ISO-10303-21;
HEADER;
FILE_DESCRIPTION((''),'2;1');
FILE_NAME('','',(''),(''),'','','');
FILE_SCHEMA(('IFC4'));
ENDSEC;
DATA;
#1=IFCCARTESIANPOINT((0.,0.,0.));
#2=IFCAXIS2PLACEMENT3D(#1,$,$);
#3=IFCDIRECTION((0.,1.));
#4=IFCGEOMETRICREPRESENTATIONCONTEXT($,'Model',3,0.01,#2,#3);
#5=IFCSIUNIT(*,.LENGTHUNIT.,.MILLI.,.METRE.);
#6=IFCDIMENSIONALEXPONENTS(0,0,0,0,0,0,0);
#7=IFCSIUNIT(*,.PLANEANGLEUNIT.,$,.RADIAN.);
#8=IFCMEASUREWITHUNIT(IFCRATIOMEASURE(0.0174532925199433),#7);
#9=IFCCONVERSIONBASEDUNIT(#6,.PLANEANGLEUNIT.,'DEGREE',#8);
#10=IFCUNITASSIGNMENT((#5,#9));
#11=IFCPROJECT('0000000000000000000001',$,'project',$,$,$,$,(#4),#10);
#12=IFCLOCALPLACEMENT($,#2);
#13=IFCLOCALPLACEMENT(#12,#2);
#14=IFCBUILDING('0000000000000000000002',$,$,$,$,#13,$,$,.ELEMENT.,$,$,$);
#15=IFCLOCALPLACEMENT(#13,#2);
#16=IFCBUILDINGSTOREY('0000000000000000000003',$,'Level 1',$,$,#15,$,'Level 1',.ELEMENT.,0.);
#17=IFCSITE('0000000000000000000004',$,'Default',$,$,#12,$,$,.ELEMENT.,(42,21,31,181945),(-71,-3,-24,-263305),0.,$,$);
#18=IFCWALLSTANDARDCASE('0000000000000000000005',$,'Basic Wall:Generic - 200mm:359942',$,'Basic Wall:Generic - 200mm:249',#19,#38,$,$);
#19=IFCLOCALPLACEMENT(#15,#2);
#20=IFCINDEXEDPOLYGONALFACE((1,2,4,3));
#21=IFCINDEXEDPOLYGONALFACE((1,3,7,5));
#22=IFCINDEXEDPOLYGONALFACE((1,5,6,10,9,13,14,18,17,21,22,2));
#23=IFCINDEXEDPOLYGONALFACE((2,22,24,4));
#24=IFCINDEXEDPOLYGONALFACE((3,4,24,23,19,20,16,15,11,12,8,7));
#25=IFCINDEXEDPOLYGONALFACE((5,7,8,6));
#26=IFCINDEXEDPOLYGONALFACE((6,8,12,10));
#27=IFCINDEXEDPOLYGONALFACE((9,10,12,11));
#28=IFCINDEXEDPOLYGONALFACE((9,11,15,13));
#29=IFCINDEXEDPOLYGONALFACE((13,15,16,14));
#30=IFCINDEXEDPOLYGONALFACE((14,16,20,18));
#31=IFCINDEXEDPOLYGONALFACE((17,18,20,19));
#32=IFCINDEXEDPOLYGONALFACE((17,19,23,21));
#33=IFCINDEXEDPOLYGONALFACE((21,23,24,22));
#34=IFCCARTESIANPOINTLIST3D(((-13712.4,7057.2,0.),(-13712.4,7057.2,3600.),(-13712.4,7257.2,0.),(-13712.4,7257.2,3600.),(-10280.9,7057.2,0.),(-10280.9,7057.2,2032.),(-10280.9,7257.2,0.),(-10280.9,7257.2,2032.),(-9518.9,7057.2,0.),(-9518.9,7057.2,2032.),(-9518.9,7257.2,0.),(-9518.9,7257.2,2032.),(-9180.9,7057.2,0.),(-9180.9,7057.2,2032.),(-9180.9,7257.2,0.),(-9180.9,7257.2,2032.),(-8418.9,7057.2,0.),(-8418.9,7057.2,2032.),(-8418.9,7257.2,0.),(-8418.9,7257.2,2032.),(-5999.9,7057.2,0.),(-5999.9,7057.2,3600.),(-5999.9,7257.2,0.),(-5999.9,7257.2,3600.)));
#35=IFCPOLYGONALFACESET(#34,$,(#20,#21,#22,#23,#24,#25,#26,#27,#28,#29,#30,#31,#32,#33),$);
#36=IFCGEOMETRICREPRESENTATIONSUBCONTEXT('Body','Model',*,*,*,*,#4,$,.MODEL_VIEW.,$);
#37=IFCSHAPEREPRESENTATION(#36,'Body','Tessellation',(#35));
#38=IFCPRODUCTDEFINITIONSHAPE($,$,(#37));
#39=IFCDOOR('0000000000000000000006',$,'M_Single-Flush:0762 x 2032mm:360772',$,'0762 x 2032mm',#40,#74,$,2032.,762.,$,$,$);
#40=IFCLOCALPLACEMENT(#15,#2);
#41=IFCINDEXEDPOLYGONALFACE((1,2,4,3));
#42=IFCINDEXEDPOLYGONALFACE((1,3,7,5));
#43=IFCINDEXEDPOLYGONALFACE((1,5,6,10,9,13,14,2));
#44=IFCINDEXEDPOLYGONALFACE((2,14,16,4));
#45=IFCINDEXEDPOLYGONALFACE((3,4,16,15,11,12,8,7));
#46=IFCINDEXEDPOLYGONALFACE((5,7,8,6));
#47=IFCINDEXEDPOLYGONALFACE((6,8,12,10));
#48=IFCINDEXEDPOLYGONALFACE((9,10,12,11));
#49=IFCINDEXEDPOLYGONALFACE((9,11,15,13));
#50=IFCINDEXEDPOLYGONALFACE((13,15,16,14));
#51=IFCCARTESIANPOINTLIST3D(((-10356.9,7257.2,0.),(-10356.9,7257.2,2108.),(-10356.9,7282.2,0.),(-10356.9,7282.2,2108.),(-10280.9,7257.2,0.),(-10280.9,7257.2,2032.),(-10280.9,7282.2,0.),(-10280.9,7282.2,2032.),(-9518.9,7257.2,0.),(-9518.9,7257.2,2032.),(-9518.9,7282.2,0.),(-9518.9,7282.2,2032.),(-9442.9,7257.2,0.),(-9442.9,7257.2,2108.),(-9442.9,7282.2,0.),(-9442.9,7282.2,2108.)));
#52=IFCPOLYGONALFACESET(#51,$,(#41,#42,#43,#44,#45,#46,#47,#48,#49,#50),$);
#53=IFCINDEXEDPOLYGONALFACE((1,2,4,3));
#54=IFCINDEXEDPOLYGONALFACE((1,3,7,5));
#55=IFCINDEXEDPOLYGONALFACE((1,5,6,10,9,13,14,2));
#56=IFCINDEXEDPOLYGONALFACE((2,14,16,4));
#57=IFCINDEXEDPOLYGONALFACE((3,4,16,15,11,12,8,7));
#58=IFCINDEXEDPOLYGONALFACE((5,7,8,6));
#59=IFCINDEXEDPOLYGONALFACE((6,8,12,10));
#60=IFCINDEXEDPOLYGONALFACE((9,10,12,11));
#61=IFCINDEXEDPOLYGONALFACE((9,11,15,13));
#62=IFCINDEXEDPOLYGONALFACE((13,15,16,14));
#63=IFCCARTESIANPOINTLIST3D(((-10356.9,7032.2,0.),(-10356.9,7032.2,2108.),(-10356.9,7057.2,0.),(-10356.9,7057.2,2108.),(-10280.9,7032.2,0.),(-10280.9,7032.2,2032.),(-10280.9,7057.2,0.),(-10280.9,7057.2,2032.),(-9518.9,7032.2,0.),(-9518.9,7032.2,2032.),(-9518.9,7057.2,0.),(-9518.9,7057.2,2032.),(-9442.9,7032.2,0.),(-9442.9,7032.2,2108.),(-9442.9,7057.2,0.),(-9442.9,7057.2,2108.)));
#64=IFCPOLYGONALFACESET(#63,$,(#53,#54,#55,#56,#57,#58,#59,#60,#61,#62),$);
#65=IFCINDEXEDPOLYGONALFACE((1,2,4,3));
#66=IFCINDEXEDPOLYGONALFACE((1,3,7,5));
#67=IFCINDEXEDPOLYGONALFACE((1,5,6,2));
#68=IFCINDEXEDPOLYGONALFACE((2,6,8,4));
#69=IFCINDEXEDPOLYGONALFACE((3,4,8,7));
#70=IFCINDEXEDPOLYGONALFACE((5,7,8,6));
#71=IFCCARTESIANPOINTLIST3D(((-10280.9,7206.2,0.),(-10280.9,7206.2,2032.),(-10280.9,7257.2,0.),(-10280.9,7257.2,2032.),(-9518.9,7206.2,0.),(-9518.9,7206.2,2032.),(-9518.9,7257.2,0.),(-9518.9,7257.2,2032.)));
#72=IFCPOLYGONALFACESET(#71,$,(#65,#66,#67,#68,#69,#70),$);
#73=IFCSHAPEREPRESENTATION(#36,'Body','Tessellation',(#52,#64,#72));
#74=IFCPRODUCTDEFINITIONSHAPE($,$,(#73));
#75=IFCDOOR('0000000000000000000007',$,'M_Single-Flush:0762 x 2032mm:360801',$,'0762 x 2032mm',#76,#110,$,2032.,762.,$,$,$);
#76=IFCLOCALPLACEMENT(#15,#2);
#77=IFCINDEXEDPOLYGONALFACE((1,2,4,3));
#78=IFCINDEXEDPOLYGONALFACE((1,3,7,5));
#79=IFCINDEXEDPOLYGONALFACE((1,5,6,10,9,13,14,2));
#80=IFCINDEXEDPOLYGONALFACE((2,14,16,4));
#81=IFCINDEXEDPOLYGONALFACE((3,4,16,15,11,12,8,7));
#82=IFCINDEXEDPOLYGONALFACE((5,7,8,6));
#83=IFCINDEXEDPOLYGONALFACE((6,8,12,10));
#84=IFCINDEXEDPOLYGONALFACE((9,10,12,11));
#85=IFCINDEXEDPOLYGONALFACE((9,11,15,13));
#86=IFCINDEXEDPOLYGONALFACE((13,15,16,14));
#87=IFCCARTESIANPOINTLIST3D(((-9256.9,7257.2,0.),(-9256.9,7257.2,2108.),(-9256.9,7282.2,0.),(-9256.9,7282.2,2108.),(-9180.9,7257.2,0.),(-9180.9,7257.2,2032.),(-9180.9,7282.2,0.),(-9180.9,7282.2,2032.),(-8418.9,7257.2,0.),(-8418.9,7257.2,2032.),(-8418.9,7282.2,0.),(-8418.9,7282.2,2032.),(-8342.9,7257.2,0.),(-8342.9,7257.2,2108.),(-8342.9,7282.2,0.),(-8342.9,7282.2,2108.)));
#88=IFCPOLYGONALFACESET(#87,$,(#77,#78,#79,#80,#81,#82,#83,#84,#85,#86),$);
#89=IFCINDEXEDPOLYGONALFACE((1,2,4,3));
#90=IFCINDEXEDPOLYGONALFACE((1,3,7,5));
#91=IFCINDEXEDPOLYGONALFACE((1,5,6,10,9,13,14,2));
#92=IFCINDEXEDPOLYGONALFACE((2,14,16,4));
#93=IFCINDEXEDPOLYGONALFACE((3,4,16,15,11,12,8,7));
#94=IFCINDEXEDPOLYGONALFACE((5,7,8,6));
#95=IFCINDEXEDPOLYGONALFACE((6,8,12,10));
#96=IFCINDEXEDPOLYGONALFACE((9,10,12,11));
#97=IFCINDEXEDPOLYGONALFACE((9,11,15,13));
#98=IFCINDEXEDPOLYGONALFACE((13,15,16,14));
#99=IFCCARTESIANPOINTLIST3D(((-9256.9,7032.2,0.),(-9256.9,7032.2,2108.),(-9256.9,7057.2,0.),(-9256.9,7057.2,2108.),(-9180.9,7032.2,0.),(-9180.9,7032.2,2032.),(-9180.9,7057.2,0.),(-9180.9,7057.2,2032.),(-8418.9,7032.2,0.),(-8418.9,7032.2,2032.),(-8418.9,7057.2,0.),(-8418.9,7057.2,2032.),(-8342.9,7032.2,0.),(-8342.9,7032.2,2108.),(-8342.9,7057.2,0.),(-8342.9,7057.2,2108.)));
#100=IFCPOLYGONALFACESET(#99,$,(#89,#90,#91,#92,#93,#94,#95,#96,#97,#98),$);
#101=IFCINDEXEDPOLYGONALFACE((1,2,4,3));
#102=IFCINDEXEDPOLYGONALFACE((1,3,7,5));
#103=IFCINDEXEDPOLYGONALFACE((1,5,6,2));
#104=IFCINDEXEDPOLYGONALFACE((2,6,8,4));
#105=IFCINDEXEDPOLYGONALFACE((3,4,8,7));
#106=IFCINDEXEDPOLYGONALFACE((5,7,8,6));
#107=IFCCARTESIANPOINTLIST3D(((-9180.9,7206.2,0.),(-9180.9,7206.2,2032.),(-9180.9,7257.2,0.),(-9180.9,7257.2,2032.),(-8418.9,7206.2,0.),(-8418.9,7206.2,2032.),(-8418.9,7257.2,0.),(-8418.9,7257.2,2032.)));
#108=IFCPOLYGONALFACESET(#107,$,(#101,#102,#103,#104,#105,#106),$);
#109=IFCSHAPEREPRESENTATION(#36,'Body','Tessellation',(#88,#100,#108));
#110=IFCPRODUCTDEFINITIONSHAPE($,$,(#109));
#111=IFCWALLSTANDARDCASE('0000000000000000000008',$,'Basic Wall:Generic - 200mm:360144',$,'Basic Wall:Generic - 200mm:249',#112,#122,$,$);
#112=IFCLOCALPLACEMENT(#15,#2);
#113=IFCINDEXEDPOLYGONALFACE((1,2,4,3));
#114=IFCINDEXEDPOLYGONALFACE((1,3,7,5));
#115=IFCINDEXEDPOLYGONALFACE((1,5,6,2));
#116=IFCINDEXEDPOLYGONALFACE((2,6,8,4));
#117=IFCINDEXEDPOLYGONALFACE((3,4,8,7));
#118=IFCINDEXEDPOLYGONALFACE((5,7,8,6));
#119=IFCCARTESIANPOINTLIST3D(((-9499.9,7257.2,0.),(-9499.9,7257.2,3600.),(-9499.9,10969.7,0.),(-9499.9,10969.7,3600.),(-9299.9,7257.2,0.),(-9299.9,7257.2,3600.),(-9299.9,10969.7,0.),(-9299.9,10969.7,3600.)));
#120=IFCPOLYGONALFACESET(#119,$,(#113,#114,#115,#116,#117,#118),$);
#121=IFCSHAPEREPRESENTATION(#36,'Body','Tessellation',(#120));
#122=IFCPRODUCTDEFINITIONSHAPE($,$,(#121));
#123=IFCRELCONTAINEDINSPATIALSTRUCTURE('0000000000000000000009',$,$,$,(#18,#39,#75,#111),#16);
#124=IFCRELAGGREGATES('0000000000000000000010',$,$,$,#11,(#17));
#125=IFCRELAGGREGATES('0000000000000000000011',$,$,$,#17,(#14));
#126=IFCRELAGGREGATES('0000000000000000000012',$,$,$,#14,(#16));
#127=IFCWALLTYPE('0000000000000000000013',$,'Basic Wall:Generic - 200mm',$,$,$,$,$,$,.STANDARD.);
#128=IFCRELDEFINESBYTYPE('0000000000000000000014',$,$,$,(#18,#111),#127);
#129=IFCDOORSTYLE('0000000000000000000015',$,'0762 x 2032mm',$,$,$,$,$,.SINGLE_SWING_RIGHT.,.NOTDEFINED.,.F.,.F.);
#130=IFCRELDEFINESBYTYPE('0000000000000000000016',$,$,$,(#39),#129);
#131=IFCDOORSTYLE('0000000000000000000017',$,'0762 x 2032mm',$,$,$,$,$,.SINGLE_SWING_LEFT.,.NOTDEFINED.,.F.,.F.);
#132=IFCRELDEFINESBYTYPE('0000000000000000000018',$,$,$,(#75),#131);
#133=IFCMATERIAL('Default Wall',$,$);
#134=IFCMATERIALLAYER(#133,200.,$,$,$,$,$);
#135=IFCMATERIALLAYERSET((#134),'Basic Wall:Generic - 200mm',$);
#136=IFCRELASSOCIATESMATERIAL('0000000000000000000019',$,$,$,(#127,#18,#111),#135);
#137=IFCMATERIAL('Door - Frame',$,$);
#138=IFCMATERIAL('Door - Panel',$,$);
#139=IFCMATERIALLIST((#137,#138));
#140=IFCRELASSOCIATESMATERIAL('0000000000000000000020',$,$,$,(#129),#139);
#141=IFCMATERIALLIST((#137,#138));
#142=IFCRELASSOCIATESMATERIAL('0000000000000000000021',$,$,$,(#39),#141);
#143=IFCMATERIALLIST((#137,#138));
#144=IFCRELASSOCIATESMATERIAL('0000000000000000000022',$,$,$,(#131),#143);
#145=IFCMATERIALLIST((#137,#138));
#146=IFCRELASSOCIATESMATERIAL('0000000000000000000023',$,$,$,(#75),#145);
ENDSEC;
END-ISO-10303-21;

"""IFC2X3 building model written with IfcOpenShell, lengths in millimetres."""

from ifc_helpers import new_model, entity, si_unit, converted_unit, direction, frame, frame_2d, origin, place, context, subcontext, project, spatial, polyline, rectangle, outline, extrude, clip, bounded_halfspace, source, transform, mapped, material, material_list, layer, layer_set, layer_usage, type_object, type_shapes, element, fill, save


model = new_model("IFC2X3")

# Units and contexts
model_context = context("Model", 3, precision=0.01, world=origin(), true_north=direction((0.0, 1.0)))
body_context = subcontext(model_context, "Body", "Model", "MODEL_VIEW")
ifc_project = project(units=[si_unit("LENGTHUNIT", "METRE", prefix="MILLI"), converted_unit("PLANEANGLEUNIT", "DEGREE", entity("IfcRatioMeasure", 0.0174532925199433), si_unit("PLANEANGLEUNIT", "RADIAN"), dimensions=[0, 0, 0, 0, 0, 0, 0])], contexts=[model_context])

# Site, building, storey
site_placement = place(None, origin())
site = spatial("IfcSite", under=ifc_project, at=site_placement, Name="Default", CompositionType="ELEMENT", RefLatitude=(42, 21, 31, 181945), RefLongitude=(-71, -3, -24, -263305), RefElevation=0.0)
building_placement = place(site_placement, origin())
building = spatial("IfcBuilding", under=site, at=building_placement, CompositionType="ELEMENT")
storey_placement = place(building_placement, origin())
storey = spatial("IfcBuildingStorey", under=building, at=storey_placement, Name="Level 1", LongName="Level 1", CompositionType="ELEMENT", Elevation=0.0)

# Shared definitions
ifc_material_1 = material(Name="Default Wall")

# Wall, openings, doors
ifc_layer_1 = layer(ifc_material_1, 200.0)
ifc_layer_set_1 = layer_set([ifc_layer_1], Name="Basic Wall:Generic - 200mm")
ifc_layer_usage_1 = layer_usage(ifc_layer_set_1, "AXIS2", "NEGATIVE", 100.0)
wall_type_1 = type_object("IfcWallType", Name="Basic Wall:Generic - 200mm", PredefinedType="STANDARD", material=ifc_layer_set_1)
wall_1_placement = place(storey_placement, frame((-13712.4, 7157.2, 0.0)))
wall_1 = element("IfcWallStandardCase", 1, at=wall_1_placement, inside=storey, type_object=wall_type_1, material=ifc_layer_usage_1, Name="Basic Wall:Generic - 200mm:359942", ObjectType="Basic Wall:Generic - 200mm:249", context=body_context, shape_type="Clipping", body=[
    clip(extrude(rectangle(XDim=7712.5, YDim=200.0, at=frame_2d((3856.2, 0.0), x_axis=(-1.0, 0.0))), origin(), (0.0, 0.0, 1.0), 3600.0), bounded_halfspace(frame((0.0, -100.0, 3600.0), z_axis=(0.0, 0.0, -1.0), x_axis=(1.0, 0.0, 0.0)), True, frame((0.0, -100.0, 3600.0)), polyline([(0.0, 0.0), (3212.5, 0.0), (3412.5, 0.0), (7712.5, 0.0), (7712.5, 200.0), (4412.5, 200.0), (4212.5, 200.0), (0.0, 200.0), (0.0, 0.0)]))),
])
opening_1_placement = place(wall_1_placement, frame((3431.5, -100.0, 0.0)))
opening_1 = element("IfcOpeningElement", 2, at=opening_1_placement, cuts=wall_1, ObjectType="Opening", context=body_context, shape_type="SweptSolid", body=[
    extrude(rectangle(XDim=762.0, YDim=2032.0, at=frame_2d((1016.0, 381.0), x_axis=(0.0, 1.0))), frame((0.0, 0.0, 0.0), z_axis=(0.0, 1.0, 0.0), x_axis=(0.0, 0.0, 1.0)), (0.0, 0.0, 1.0), 200.0),
])
opening_2_placement = place(wall_1_placement, frame((4531.5, -100.0, 0.0)))
opening_2 = element("IfcOpeningElement", 3, at=opening_2_placement, cuts=wall_1, ObjectType="Opening", context=body_context, shape_type="SweptSolid", body=[
    extrude(rectangle(XDim=762.0, YDim=2032.0, at=frame_2d((1016.0, 381.0), x_axis=(0.0, -1.0))), frame((0.0, 0.0, 0.0), z_axis=(0.0, 1.0, 0.0), x_axis=(0.0, 0.0, 1.0)), (0.0, 0.0, 1.0), 200.0),
])
ifc_material_2 = material(Name="Door - Frame")
ifc_material_3 = material(Name="Door - Panel")
ifc_material_list_1 = material_list([ifc_material_2, ifc_material_3])
ifc_material_list_2 = material_list([ifc_material_2, ifc_material_3])
door_style_1 = type_object("IfcDoorStyle", Name="0762 x 2032mm", ConstructionType="NOTDEFINED", OperationType="SINGLE_SWING_RIGHT", ParameterTakesPrecedence=False, Sizeable=False, material=ifc_material_list_2)
shared_shape_1 = source(origin(), body_context, "Body", "SweptSolid", [
    extrude(outline(polyline([(-457.0, -1073.0), (457.0, -1073.0), (457.0, 1035.0), (381.0, 1035.0), (381.0, -997.0), (-381.0, -997.0), (-381.0, 1035.0), (-457.0, 1035.0), (-457.0, -1073.0)])), frame((381.0, 200.0, 1035.0), z_axis=(0.0, 1.0, 0.0), x_axis=(1.0, 0.0, 0.0)), (0.0, 0.0, 1.0), 25.0),
    extrude(outline(polyline([(-1073.0, -457.0), (1035.0, -457.0), (1035.0, -381.0), (-997.0, -381.0), (-997.0, 381.0), (1035.0, 381.0), (1035.0, 457.0), (-1073.0, 457.0), (-1073.0, -457.0)])), frame((381.0, -25.0, 1035.0), z_axis=(0.0, 1.0, 0.0), x_axis=(0.0, 0.0, -1.0)), (0.0, 0.0, 1.0), 25.0),
    extrude(rectangle(XDim=51.0, YDim=762.0, at=frame_2d((0.0, 0.0), x_axis=(1.0, 0.0))), frame((381.0, 174.5, 0.0), z_axis=(0.0, 0.0, 1.0), x_axis=(0.0, 1.0, 0.0)), (0.0, 0.0, 1.0), 2032.0),
])
type_shapes(door_style_1, [shared_shape_1])
door_1_placement = place(opening_1_placement, origin())
door_1 = element("IfcDoor", 4, at=door_1_placement, inside=storey, type_object=door_style_1, material=ifc_material_list_1, Name="M_Single-Flush:0762 x 2032mm:360772", ObjectType="0762 x 2032mm", OverallHeight=2032.0, OverallWidth=762.0, context=body_context, shape_type="MappedRepresentation", body=[
    mapped(shared_shape_1, transform((0.0, 0.0, 0.0), scale=1.0)),
])
fill(opening_1, door_1)
ifc_material_list_3 = material_list([ifc_material_2, ifc_material_3])
ifc_material_list_4 = material_list([ifc_material_2, ifc_material_3])
door_style_2 = type_object("IfcDoorStyle", Name="0762 x 2032mm", ConstructionType="NOTDEFINED", OperationType="SINGLE_SWING_LEFT", ParameterTakesPrecedence=False, Sizeable=False, material=ifc_material_list_4)
shared_shape_2 = source(origin(), body_context, "Body", "SweptSolid", [
    extrude(outline(polyline([(-457.0, -1073.0), (457.0, -1073.0), (457.0, 1035.0), (381.0, 1035.0), (381.0, -997.0), (-381.0, -997.0), (-381.0, 1035.0), (-457.0, 1035.0), (-457.0, -1073.0)])), frame((381.0, 225.0, 1035.0), z_axis=(0.0, -1.0, 0.0), x_axis=(-1.0, 0.0, 0.0)), (0.0, 0.0, 1.0), 25.0),
    extrude(outline(polyline([(-1073.0, -457.0), (1035.0, -457.0), (1035.0, -381.0), (-997.0, -381.0), (-997.0, 381.0), (1035.0, 381.0), (1035.0, 457.0), (-1073.0, 457.0), (-1073.0, -457.0)])), frame((381.0, 0.0, 1035.0), z_axis=(0.0, -1.0, 0.0), x_axis=(0.0, 0.0, -1.0)), (0.0, 0.0, 1.0), 25.0),
    extrude(rectangle(XDim=762.0, YDim=51.0, at=frame_2d((0.0, 0.0), x_axis=(1.0, 0.0))), frame((381.0, 174.5, 0.0)), (0.0, 0.0, 1.0), 2032.0),
])
type_shapes(door_style_2, [shared_shape_2])
door_2_placement = place(opening_2_placement, origin())
door_2 = element("IfcDoor", 5, at=door_2_placement, inside=storey, type_object=door_style_2, material=ifc_material_list_3, Name="M_Single-Flush:0762 x 2032mm:360801", ObjectType="0762 x 2032mm", OverallHeight=2032.0, OverallWidth=762.0, context=body_context, shape_type="MappedRepresentation", body=[
    mapped(shared_shape_2, transform((0.0, 0.0, 0.0), scale=1.0)),
])
fill(opening_2, door_2)

# Wall
ifc_layer_usage_2 = layer_usage(ifc_layer_set_1, "AXIS2", "NEGATIVE", 100.0)
wall_2_placement = place(storey_placement, frame((-9399.9, 7257.2, 0.0), z_axis=(0.0, 0.0, 1.0), x_axis=(0.0, 1.0, 0.0)))
element("IfcWallStandardCase", 6, at=wall_2_placement, inside=storey, type_object=wall_type_1, material=ifc_layer_usage_2, Name="Basic Wall:Generic - 200mm:360144", ObjectType="Basic Wall:Generic - 200mm:249", context=body_context, shape_type="Clipping", body=[
    clip(extrude(rectangle(XDim=3712.5, YDim=200.0, at=frame_2d((1856.3, 0.0), x_axis=(-1.0, 0.0))), origin(), (0.0, 0.0, 1.0), 3600.0), bounded_halfspace(frame((0.0, -100.0, 3600.0), z_axis=(0.0, 0.0, -1.0), x_axis=(0.0, -1.0, 0.0)), True, frame((0.0, -100.0, 3600.0)), polyline([(0.0, 0.0), (3712.5, 0.0), (3712.5, 200.0), (0.0, 200.0), (0.0, 0.0)]))),
])

save(model, "model.ifc")
